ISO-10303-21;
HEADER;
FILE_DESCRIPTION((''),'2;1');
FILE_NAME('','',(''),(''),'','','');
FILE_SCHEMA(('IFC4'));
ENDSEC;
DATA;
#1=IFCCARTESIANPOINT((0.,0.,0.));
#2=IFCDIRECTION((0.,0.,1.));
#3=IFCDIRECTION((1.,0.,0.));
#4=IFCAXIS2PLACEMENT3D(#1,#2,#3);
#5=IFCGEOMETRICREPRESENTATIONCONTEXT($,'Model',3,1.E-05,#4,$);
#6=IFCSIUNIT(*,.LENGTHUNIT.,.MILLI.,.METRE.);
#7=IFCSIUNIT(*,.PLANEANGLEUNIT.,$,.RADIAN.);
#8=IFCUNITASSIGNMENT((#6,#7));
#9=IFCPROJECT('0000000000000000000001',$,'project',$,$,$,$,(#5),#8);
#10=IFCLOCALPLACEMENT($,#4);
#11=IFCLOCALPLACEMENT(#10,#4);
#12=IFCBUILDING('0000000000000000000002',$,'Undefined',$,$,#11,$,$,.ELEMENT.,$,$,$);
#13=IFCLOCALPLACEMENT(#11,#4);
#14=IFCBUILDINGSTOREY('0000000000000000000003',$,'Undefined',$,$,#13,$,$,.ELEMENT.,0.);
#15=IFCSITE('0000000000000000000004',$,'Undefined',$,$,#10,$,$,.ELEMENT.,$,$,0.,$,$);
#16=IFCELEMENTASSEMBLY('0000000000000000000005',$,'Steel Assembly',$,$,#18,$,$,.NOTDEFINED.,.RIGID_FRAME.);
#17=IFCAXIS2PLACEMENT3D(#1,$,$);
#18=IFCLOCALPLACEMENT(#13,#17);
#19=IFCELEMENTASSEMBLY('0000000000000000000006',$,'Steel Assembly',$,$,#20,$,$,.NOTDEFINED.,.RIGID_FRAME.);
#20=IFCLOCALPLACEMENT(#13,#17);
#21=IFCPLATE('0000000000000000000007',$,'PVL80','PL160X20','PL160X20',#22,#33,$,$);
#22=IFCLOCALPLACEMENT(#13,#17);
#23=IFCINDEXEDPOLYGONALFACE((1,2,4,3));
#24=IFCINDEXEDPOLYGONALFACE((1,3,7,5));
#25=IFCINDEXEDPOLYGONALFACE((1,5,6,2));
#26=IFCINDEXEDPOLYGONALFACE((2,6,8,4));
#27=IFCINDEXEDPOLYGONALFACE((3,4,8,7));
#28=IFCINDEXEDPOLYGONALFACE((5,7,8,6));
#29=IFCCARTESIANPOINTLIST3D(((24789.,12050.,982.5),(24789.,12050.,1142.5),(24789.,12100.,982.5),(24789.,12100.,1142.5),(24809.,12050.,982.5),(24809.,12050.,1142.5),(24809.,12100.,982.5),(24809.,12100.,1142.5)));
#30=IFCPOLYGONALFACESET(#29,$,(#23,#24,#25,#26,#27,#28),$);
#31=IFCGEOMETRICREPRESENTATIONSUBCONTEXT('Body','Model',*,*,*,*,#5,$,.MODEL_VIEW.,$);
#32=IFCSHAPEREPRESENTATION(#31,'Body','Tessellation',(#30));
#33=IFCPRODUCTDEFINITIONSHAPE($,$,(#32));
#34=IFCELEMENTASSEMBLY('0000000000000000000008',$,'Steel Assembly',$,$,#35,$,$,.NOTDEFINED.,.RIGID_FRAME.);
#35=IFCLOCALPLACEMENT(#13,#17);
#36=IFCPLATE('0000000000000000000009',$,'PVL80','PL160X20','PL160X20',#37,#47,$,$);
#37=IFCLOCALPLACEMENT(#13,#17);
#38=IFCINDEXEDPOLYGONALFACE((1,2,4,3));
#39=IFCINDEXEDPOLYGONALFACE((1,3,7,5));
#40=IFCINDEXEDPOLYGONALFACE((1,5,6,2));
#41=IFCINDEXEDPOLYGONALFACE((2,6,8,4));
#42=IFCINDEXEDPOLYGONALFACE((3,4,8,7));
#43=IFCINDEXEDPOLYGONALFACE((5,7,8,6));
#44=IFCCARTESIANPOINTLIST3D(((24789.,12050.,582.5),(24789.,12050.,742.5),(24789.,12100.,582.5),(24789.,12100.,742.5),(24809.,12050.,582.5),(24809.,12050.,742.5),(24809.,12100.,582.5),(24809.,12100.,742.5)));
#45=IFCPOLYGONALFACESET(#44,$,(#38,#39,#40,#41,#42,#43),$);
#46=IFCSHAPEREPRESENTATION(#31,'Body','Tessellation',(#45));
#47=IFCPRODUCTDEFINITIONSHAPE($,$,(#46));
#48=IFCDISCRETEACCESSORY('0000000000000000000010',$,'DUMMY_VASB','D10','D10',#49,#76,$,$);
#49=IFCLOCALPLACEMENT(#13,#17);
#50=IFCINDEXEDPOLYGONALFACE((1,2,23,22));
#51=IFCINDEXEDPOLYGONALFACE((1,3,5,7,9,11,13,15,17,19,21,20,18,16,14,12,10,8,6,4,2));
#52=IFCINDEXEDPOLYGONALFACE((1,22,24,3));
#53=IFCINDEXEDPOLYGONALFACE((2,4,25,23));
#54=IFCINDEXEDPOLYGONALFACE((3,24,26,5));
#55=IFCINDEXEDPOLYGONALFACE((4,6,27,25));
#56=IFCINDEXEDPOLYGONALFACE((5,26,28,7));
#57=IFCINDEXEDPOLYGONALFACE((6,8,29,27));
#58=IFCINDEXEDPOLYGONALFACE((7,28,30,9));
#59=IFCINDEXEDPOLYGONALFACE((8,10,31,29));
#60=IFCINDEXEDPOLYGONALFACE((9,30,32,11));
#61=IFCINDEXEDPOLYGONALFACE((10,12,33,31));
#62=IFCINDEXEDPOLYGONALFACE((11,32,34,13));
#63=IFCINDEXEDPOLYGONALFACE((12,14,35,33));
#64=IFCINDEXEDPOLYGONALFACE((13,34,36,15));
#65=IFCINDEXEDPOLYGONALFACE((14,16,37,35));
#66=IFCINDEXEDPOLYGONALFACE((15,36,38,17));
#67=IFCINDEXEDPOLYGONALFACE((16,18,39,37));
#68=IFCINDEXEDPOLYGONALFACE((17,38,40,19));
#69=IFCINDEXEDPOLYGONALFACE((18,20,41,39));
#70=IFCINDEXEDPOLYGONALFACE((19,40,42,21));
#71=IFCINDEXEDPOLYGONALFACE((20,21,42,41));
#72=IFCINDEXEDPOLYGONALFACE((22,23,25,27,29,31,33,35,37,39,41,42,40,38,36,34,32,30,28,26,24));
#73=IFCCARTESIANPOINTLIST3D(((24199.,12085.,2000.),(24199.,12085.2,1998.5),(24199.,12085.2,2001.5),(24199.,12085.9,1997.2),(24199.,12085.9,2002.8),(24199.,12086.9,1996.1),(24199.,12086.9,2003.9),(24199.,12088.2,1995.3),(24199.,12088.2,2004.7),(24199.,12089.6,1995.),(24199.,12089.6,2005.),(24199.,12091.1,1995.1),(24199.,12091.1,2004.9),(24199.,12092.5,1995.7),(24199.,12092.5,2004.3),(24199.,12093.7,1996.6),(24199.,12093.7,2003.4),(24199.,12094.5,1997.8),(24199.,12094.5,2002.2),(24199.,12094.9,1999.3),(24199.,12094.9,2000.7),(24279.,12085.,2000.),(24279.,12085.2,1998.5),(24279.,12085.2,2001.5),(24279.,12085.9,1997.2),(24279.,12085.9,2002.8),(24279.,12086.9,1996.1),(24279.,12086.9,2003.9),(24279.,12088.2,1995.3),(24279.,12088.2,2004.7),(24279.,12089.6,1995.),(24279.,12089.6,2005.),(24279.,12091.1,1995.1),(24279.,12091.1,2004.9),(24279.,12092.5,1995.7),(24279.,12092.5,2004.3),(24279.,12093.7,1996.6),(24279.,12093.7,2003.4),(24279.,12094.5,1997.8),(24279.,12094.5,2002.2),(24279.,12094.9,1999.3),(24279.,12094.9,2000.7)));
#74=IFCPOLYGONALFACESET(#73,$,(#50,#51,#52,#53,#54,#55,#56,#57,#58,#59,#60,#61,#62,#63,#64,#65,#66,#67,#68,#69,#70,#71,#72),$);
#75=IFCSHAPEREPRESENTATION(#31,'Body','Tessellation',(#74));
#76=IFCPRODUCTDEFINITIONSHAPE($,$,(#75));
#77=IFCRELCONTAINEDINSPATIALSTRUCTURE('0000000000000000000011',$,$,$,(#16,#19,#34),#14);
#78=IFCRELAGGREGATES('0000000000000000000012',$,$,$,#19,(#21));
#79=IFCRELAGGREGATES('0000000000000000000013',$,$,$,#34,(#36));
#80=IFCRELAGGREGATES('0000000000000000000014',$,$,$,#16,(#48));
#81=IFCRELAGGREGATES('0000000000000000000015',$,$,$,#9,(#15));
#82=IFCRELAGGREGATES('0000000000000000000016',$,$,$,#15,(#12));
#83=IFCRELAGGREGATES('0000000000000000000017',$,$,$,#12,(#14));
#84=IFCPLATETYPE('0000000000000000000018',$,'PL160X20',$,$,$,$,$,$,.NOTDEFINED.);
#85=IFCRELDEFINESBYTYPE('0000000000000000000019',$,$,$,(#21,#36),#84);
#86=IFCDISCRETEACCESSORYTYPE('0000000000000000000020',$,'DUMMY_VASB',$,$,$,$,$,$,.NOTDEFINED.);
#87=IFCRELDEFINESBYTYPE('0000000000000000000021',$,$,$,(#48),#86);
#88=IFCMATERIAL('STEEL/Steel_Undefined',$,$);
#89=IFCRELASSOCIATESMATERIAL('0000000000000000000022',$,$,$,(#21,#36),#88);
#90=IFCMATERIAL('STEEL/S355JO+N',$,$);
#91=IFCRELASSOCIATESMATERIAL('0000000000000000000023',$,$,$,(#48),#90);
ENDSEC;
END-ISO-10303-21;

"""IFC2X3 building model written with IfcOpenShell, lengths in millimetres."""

from ifc_helpers import new_model, si_unit, frame, origin_with_axes, origin_2d_with_axis, place, context, subcontext, project, spatial, polyline, circle, outline, extrude, material, type_object, element, aggregate, save


model = new_model("IFC2X3")

# Units and contexts
model_context = context("Model", 3, precision=1e-05, world=origin_with_axes())
body_context = subcontext(model_context, "Body", "Model", "MODEL_VIEW")
ifc_project = project(units=[si_unit("LENGTHUNIT", "METRE", prefix="MILLI"), si_unit("PLANEANGLEUNIT", "RADIAN")], contexts=[model_context])

# Site, building, storey
site_placement = place(None, origin_with_axes())
site = spatial("IfcSite", under=ifc_project, at=site_placement, Name="Undefined", CompositionType="ELEMENT", RefElevation=0.0)
building_placement = place(site_placement, origin_with_axes())
building = spatial("IfcBuilding", under=site, at=building_placement, Name="Undefined", CompositionType="ELEMENT")
storey_placement = place(building_placement, origin_with_axes())
storey = spatial("IfcBuildingStorey", under=building, at=storey_placement, Name="Undefined", CompositionType="ELEMENT", Elevation=0.0)

# Shared definitions
ifc_material_1 = material(Name="STEEL/Steel_Undefined")

# Element assembly
assembly_1_placement = place(storey_placement, origin_with_axes())
assembly_1 = element("IfcElementAssembly", 1, at=assembly_1_placement, inside=storey, Name="Steel Assembly", AssemblyPlace="NOTDEFINED", PredefinedType="RIGID_FRAME")
ifc_material_2 = material(Name="STEEL/S355JO+N")

# Element assemblies, plates
plate_type = type_object("IfcPlateType", Name="PL160X20", PredefinedType="NOTDEFINED")
assembly_2_placement = place(storey_placement, origin_with_axes())
assembly_2 = element("IfcElementAssembly", 2, at=assembly_2_placement, inside=storey, Name="Steel Assembly", AssemblyPlace="NOTDEFINED", PredefinedType="RIGID_FRAME")
plate_1_placement = place(assembly_2_placement, frame((24809.0, 12100.0, 1062.5), z_axis=(0.0, 0.0, -1.0), x_axis=(0.0, -1.0, 0.0)))
plate_1 = element("IfcPlate", 3, at=plate_1_placement, type_object=plate_type, material=ifc_material_1, Name="PVL80", Description="PL160X20", ObjectType="PL160X20", context=body_context, shape_type="SweptSolid", body=[
    extrude(outline(polyline([(0.0, 0.0), (50.0, 0.0), (50.0, 20.0), (0.0, 20.0), (0.0, 0.0)])), frame((0.0, 0.0, -80.0), z_axis=(0.0, 0.0, 1.0), x_axis=(1.0, 0.0, 0.0)), (0.0, 0.0, 1.0), 160.0),
])
assembly_3_placement = place(storey_placement, origin_with_axes())
assembly_3 = element("IfcElementAssembly", 4, at=assembly_3_placement, inside=storey, Name="Steel Assembly", AssemblyPlace="NOTDEFINED", PredefinedType="RIGID_FRAME")
plate_2_placement = place(assembly_3_placement, frame((24809.0, 12100.0, 662.5), z_axis=(0.0, 0.0, -1.0), x_axis=(0.0, -1.0, 0.0)))
plate_2 = element("IfcPlate", 5, at=plate_2_placement, type_object=plate_type, material=ifc_material_1, Name="PVL80", Description="PL160X20", ObjectType="PL160X20", context=body_context, shape_type="SweptSolid", body=[
    extrude(outline(polyline([(0.0, 0.0), (50.0, 0.0), (50.0, 20.0), (0.0, 20.0), (0.0, 0.0)])), frame((0.0, 0.0, -80.0), z_axis=(0.0, 0.0, 1.0), x_axis=(1.0, 0.0, 0.0)), (0.0, 0.0, 1.0), 160.0),
])

aggregate(assembly_2, [plate_1])
aggregate(assembly_3, [plate_2])

# Discrete accessory
discrete_accessory_type = type_object("IfcDiscreteAccessoryType", Name="DUMMY_VASB")
discrete_accessory_placement = place(assembly_1_placement, frame((24199.0, 12090.0, 2000.0), z_axis=(0.0, 0.0, 1.0), x_axis=(1.0, 0.0, 0.0)))
discrete_accessory = element("IfcDiscreteAccessory", 6, at=discrete_accessory_placement, type_object=discrete_accessory_type, material=ifc_material_2, Name="DUMMY_VASB", Description="D10", ObjectType="D10", context=body_context, shape_type="SweptSolid", body=[
    extrude(circle(Radius=5.0, at=origin_2d_with_axis()), frame((80.0, 0.0, 0.0), z_axis=(-1.0, 0.0, 0.0), x_axis=(0.0, -1.0, 0.0)), (0.0, 0.0, 1.0), 80.0),
])
aggregate(assembly_1, [discrete_accessory])

save(model, "model.ifc")
